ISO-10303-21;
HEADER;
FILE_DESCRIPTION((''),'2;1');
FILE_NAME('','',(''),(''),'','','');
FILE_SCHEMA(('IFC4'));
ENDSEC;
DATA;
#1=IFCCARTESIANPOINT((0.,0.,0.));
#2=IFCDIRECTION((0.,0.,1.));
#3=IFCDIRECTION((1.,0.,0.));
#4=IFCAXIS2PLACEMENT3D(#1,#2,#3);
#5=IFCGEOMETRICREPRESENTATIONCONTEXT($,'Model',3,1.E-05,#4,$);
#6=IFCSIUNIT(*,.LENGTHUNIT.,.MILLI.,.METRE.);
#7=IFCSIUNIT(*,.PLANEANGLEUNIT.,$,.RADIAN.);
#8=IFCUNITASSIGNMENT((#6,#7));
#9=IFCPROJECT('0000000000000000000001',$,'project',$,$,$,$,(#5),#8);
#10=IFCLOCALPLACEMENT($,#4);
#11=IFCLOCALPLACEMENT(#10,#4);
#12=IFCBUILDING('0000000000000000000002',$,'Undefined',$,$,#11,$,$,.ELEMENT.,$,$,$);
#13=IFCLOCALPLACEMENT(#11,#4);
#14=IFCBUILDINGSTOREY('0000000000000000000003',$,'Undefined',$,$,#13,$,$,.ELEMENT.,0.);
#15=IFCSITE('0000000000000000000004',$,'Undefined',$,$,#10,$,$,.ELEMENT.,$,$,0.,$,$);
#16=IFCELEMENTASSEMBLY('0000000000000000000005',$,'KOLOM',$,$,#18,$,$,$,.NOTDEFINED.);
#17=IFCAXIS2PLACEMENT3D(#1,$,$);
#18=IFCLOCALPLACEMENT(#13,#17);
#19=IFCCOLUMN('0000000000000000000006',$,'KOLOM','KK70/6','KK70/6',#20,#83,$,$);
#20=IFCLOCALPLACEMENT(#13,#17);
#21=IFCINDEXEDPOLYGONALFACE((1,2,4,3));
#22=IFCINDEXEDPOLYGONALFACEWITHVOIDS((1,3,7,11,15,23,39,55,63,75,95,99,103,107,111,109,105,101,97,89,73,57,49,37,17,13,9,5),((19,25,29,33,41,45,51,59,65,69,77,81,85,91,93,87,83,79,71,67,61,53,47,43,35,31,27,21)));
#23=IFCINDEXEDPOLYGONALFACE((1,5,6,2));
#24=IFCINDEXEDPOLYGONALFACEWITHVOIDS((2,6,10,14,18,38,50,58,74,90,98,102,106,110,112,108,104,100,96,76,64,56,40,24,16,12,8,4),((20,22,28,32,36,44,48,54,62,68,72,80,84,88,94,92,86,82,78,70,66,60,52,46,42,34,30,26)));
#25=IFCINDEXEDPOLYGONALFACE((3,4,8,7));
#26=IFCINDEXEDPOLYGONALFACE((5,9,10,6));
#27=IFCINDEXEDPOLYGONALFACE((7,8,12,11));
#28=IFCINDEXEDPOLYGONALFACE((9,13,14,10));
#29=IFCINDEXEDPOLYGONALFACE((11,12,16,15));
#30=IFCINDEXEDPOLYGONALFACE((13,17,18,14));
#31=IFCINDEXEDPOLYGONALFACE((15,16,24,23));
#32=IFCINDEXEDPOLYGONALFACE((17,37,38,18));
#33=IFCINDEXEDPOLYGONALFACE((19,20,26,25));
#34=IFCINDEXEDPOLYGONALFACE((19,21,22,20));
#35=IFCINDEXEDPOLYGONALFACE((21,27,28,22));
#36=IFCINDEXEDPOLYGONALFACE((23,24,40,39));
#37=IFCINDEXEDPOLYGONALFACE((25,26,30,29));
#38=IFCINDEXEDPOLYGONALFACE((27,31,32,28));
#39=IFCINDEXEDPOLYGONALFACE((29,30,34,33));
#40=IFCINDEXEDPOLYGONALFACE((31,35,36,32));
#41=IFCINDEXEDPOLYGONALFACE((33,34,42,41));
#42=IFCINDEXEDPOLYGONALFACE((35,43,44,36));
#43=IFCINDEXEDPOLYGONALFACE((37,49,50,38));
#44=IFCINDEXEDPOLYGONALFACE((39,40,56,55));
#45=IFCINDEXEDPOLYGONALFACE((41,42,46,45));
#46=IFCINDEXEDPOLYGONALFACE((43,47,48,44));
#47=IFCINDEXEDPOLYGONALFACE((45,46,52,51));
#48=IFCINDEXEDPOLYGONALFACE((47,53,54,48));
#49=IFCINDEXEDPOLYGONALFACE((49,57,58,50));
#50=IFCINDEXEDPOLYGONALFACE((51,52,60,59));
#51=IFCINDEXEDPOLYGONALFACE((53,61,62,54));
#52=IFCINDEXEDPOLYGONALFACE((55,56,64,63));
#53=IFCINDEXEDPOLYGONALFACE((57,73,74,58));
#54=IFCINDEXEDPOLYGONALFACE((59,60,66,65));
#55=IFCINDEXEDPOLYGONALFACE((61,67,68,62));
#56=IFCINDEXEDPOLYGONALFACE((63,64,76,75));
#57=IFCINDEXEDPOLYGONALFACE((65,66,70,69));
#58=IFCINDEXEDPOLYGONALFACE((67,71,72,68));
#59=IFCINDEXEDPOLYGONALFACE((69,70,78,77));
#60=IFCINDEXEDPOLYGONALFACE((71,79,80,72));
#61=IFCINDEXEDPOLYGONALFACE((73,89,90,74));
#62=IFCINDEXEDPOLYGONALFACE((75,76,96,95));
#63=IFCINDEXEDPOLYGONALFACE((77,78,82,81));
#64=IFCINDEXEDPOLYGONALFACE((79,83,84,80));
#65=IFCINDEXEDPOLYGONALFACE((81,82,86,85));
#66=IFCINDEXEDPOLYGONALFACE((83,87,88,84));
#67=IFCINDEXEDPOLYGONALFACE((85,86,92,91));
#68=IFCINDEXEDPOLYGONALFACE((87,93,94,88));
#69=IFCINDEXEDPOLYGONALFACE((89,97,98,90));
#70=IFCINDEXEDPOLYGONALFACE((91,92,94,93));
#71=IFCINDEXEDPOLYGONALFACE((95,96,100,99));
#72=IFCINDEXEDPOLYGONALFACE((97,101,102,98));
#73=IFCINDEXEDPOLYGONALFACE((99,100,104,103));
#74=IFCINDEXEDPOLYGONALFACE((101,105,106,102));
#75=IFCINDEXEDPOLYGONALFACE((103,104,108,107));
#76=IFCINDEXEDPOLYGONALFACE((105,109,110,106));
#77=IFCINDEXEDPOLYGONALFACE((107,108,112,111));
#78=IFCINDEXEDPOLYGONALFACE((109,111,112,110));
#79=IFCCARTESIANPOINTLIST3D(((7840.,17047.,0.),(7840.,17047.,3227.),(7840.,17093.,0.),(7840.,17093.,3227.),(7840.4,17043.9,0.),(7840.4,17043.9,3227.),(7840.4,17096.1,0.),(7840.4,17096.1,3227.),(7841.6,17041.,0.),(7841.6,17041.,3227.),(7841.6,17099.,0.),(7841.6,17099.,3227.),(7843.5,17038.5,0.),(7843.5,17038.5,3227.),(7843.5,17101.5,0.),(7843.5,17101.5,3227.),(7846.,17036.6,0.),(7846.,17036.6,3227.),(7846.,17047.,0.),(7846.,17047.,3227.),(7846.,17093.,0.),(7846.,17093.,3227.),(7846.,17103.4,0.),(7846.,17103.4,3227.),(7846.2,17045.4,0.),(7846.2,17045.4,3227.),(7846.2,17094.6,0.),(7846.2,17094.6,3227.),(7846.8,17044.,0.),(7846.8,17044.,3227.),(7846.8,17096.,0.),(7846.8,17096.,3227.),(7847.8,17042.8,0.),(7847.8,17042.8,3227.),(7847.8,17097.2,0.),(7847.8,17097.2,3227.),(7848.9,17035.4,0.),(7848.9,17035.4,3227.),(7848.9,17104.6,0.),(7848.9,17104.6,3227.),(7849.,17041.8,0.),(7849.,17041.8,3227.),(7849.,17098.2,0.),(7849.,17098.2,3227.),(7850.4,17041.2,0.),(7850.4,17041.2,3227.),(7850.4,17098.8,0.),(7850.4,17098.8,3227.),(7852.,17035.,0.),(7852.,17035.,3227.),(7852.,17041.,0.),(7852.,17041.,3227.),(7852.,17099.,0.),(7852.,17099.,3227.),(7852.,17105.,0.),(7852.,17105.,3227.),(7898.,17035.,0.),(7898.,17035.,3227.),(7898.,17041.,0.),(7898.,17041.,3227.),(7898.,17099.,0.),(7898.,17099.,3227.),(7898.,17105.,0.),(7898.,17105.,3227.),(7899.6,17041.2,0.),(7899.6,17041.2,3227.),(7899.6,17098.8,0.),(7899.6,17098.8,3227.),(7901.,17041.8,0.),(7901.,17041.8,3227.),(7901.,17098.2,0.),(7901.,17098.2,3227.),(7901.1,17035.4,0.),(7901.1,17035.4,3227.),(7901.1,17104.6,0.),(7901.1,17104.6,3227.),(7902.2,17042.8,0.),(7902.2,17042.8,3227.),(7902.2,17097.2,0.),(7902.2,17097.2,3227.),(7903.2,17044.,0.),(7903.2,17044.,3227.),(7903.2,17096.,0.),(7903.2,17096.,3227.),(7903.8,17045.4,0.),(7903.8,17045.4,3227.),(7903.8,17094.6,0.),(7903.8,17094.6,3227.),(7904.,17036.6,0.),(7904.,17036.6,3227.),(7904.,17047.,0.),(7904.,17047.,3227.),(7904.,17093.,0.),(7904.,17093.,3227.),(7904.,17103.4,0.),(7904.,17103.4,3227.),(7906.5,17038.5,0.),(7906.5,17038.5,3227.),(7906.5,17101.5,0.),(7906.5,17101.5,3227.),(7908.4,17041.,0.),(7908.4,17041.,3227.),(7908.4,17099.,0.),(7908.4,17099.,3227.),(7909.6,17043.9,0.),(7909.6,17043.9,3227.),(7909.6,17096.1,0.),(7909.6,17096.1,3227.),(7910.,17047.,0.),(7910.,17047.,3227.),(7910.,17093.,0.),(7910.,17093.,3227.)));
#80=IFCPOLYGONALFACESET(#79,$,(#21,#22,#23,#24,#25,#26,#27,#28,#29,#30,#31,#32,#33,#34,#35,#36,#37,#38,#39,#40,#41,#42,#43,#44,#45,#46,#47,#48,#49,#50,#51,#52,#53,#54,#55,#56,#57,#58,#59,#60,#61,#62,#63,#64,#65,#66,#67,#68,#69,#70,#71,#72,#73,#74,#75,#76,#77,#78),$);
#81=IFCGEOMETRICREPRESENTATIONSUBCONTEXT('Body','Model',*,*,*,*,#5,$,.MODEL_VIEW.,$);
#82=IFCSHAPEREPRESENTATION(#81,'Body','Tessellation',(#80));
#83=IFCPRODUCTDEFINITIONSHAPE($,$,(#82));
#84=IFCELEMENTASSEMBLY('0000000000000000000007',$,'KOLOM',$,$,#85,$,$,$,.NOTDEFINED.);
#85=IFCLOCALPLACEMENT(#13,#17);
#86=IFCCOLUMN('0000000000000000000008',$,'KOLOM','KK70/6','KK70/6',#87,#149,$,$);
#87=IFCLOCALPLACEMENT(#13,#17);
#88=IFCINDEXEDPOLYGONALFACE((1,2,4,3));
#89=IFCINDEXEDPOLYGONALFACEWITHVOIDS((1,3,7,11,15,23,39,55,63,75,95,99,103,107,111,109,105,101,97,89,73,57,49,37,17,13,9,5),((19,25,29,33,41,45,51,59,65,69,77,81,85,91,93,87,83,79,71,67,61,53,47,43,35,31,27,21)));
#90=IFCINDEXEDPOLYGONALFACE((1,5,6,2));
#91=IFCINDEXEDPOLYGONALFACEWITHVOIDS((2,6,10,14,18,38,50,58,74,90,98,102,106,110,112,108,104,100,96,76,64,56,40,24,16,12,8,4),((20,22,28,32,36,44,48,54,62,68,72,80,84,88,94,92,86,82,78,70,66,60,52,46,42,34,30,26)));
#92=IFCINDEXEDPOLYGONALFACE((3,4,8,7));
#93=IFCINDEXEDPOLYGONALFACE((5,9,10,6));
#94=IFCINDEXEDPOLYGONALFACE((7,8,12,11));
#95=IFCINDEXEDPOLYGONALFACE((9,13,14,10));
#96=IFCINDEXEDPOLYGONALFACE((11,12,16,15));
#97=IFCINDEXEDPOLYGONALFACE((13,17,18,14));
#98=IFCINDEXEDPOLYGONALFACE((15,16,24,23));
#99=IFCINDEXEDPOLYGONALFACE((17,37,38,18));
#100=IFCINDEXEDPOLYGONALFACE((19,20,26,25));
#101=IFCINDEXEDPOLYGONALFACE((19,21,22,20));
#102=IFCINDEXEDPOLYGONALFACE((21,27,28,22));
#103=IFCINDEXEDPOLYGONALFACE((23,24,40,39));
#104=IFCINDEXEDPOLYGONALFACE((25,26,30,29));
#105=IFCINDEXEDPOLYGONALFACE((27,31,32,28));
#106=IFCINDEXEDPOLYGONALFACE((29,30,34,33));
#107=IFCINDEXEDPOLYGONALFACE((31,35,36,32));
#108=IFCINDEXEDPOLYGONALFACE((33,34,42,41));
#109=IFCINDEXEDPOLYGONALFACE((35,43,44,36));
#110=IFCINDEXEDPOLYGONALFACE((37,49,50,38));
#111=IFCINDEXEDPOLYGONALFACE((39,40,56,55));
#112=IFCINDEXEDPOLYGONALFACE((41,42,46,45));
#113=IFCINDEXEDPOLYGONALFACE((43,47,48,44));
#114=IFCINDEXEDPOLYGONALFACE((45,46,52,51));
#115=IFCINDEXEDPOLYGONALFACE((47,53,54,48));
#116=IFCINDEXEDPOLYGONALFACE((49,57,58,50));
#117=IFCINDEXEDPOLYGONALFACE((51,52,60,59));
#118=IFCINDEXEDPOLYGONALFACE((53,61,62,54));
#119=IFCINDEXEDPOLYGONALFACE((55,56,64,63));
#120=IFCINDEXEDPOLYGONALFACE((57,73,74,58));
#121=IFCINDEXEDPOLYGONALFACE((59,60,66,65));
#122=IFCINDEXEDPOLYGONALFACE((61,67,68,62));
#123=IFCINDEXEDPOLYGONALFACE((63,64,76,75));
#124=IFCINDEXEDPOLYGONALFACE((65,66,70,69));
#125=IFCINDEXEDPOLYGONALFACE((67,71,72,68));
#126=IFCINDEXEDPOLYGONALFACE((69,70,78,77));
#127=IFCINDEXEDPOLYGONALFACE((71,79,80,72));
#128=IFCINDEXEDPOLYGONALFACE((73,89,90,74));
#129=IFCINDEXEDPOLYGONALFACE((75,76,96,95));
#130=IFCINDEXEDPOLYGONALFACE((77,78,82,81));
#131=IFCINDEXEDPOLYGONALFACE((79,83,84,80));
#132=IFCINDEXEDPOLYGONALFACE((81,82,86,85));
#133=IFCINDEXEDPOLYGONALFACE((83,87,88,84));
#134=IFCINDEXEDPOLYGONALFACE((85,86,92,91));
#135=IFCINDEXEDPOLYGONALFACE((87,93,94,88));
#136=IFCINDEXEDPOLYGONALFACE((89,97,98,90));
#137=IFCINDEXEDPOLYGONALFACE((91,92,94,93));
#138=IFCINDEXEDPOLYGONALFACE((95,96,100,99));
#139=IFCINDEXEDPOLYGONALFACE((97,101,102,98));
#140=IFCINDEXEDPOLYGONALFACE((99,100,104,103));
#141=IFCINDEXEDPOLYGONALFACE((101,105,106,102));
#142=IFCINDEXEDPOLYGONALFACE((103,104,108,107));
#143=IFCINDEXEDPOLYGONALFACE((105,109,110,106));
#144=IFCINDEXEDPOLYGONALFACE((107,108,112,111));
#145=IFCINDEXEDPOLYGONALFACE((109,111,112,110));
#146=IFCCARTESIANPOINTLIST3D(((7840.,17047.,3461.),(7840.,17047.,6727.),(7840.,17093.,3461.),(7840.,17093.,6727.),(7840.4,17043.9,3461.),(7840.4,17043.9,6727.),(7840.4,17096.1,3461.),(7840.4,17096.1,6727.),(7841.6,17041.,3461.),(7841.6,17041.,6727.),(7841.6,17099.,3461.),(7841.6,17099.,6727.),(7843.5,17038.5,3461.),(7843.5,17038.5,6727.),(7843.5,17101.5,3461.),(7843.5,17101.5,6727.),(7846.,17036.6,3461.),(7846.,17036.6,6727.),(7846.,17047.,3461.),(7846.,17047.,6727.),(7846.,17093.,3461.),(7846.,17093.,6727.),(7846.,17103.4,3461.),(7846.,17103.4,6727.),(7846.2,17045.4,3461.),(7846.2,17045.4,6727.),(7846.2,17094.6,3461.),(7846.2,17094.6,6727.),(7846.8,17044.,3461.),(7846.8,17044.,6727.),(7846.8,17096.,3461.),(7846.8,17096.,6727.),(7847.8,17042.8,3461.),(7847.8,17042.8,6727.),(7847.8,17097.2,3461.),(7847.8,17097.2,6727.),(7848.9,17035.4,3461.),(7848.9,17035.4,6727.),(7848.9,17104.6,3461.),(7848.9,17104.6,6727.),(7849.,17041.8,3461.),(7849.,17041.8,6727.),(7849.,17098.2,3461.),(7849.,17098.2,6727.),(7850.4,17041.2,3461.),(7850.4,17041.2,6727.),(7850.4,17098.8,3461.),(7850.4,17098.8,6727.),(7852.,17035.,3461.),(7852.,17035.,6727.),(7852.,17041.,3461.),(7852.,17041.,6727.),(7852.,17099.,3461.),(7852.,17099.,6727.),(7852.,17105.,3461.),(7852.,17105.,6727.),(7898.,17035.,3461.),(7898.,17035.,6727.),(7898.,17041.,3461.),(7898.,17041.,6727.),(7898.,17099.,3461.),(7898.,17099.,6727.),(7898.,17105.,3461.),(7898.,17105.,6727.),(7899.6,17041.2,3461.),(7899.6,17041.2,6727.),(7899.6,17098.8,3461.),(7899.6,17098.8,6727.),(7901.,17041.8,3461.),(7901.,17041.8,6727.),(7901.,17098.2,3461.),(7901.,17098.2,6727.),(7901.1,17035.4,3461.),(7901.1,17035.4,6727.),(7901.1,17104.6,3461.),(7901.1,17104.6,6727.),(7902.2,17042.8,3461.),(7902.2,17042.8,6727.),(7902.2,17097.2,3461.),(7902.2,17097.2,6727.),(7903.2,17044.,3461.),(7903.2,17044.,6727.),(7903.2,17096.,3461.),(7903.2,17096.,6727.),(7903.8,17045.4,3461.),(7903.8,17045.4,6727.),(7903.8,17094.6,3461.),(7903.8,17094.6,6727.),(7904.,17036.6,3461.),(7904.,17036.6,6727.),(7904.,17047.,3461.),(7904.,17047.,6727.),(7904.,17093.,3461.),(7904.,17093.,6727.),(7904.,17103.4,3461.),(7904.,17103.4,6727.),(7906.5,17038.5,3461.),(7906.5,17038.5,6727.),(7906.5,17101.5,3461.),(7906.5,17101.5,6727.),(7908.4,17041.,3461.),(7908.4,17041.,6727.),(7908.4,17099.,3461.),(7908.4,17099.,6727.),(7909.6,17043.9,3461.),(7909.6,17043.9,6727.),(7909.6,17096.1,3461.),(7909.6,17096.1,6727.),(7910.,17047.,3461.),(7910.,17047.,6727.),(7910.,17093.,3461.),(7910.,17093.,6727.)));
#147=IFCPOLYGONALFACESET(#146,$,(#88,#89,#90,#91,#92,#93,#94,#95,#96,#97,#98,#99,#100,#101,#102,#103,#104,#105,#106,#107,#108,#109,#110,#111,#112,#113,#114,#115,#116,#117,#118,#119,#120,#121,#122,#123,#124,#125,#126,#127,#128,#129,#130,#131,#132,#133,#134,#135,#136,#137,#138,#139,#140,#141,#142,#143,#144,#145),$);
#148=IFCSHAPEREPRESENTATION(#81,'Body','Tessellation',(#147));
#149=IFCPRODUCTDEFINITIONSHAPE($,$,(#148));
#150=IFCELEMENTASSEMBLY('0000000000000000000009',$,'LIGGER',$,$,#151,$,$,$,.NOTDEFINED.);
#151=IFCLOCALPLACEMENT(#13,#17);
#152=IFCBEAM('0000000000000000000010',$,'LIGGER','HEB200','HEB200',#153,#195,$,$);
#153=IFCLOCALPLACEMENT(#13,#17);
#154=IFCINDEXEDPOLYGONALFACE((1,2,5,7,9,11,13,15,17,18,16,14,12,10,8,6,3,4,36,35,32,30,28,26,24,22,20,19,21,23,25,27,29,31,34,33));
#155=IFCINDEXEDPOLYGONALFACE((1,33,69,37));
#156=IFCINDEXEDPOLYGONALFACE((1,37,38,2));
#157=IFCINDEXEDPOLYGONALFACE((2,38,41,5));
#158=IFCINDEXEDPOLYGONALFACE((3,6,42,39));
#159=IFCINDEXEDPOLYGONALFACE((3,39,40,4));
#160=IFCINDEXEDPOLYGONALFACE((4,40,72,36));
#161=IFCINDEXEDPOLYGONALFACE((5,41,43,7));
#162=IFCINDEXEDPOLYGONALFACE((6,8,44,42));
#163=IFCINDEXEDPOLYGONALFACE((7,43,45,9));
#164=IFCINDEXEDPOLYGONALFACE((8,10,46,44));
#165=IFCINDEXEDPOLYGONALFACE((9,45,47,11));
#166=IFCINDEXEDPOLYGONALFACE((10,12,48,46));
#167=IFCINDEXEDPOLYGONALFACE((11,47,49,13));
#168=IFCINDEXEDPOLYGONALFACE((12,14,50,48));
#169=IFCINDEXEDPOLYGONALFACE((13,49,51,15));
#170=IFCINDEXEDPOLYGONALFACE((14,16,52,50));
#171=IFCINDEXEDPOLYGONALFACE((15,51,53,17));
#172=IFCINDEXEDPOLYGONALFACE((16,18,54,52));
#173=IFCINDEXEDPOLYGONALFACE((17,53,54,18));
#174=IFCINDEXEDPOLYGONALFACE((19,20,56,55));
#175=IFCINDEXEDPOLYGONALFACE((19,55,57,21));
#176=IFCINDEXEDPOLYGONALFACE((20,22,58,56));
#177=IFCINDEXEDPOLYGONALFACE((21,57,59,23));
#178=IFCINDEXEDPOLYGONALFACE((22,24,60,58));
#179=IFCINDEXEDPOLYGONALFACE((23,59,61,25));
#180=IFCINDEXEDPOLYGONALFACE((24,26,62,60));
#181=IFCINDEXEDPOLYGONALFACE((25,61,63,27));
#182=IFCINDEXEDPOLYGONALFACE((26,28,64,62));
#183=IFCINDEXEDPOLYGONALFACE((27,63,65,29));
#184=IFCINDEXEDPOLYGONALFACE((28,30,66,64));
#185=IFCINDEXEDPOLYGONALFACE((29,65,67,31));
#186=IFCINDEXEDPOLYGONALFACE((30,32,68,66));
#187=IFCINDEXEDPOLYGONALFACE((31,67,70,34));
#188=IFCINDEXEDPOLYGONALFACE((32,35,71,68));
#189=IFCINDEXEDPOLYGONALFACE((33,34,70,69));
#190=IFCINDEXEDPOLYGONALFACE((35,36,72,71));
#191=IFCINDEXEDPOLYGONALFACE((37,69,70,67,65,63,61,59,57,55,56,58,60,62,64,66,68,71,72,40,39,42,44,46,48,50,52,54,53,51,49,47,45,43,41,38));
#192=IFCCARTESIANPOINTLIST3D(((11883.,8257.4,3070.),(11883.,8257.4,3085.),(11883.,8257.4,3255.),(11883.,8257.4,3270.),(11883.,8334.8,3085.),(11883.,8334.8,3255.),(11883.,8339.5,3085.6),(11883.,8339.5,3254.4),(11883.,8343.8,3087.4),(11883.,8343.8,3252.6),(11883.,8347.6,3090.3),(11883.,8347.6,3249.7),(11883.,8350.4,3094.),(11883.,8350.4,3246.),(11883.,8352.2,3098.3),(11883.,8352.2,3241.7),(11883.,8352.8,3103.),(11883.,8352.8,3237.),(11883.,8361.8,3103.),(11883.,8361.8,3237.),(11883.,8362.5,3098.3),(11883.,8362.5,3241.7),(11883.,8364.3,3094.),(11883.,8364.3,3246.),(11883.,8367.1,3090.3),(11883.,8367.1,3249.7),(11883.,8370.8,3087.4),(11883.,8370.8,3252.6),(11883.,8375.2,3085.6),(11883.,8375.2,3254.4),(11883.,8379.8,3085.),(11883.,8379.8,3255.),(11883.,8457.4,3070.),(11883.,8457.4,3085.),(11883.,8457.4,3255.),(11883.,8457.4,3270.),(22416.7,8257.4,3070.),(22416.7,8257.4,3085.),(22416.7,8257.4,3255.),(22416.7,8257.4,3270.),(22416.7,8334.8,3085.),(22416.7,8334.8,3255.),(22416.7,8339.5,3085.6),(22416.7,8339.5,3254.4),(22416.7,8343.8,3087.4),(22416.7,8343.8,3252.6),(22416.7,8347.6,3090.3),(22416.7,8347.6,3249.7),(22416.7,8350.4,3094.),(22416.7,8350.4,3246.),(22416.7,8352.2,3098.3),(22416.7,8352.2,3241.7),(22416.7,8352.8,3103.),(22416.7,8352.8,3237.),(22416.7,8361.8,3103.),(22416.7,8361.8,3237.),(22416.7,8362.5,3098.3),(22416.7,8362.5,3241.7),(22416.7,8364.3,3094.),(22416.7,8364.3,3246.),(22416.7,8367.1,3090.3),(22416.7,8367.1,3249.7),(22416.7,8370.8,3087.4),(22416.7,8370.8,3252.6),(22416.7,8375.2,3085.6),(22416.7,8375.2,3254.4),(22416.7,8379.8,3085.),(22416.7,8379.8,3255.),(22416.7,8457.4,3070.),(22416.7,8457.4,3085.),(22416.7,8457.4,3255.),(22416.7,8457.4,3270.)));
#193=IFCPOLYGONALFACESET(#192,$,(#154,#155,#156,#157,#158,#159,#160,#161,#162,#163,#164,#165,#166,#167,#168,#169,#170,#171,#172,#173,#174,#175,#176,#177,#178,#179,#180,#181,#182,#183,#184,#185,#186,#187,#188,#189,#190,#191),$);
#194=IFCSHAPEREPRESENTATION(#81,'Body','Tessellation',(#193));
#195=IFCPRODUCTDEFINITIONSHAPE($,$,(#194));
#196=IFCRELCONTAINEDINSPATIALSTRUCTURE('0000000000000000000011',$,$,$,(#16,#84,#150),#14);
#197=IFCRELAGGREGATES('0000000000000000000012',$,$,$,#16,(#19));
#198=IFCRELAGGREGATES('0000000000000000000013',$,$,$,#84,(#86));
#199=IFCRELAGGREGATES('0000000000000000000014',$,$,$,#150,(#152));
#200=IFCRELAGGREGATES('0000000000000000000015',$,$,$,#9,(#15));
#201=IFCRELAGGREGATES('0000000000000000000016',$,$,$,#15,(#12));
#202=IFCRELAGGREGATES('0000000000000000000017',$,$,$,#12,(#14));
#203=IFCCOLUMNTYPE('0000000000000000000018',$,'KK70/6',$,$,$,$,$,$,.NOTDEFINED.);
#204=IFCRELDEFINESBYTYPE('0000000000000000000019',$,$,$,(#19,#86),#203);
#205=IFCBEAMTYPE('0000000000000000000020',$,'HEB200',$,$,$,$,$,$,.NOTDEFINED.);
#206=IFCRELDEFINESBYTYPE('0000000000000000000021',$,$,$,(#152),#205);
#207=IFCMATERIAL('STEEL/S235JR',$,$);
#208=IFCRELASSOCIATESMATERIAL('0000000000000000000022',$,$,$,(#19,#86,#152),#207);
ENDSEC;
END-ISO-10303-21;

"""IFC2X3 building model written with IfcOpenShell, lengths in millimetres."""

from ifc_helpers import new_model, si_unit, frame, origin_with_axes, origin_2d_with_axis, place, context, subcontext, project, spatial, hollow_rectangle, i_section, extrude, material, type_object, element, aggregate, save


model = new_model("IFC2X3")

# Units and contexts
model_context = context("Model", 3, precision=1e-05, world=origin_with_axes())
body_context = subcontext(model_context, "Body", "Model", "MODEL_VIEW")
ifc_project = project(units=[si_unit("LENGTHUNIT", "METRE", prefix="MILLI"), si_unit("PLANEANGLEUNIT", "RADIAN")], contexts=[model_context])

# Site, building, storey
site_placement = place(None, origin_with_axes())
site = spatial("IfcSite", under=ifc_project, at=site_placement, Name="Undefined", CompositionType="ELEMENT", RefElevation=0.0)
building_placement = place(site_placement, origin_with_axes())
building = spatial("IfcBuilding", under=site, at=building_placement, Name="Undefined", CompositionType="ELEMENT")
storey_placement = place(building_placement, origin_with_axes())
storey = spatial("IfcBuildingStorey", under=building, at=storey_placement, Name="Undefined", CompositionType="ELEMENT", Elevation=0.0)

# Element assemblies, columns
ifc_material = material(Name="STEEL/S235JR")
column_type = type_object("IfcColumnType", Name="KK70/6", PredefinedType="NOTDEFINED")
assembly_1_placement = place(storey_placement, origin_with_axes())
assembly_1 = element("IfcElementAssembly", 1, at=assembly_1_placement, inside=storey, Name="KOLOM", PredefinedType="NOTDEFINED")
column_1_placement = place(assembly_1_placement, frame((7875.0, 17070.0, 0.0), z_axis=(0.0, 0.0, 1.0), x_axis=(1.0, 0.0, 0.0)))
column_1 = element("IfcColumn", 2, at=column_1_placement, type_object=column_type, material=ifc_material, Name="KOLOM", Description="KK70/6", ObjectType="KK70/6", context=body_context, shape_type="SweptSolid", body=[
    extrude(hollow_rectangle(XDim=70.0, YDim=70.0, WallThickness=6.0, InnerFilletRadius=6.0, OuterFilletRadius=12.0, at=origin_2d_with_axis()), frame((0.0, 0.0, 3227.0), z_axis=(0.0, 0.0, -1.0), x_axis=(0.0, -1.0, 0.0)), (0.0, 0.0, 1.0), 3227.0),
])
assembly_2_placement = place(storey_placement, origin_with_axes())
assembly_2 = element("IfcElementAssembly", 3, at=assembly_2_placement, inside=storey, Name="KOLOM", PredefinedType="NOTDEFINED")
column_2_placement = place(assembly_2_placement, frame((7875.0, 17070.0, 3450.0), z_axis=(0.0, 0.0, 1.0), x_axis=(1.0, 0.0, 0.0)))
column_2 = element("IfcColumn", 4, at=column_2_placement, type_object=column_type, material=ifc_material, Name="KOLOM", Description="KK70/6", ObjectType="KK70/6", context=body_context, shape_type="SweptSolid", body=[
    extrude(hollow_rectangle(XDim=70.0, YDim=70.0, WallThickness=6.0, InnerFilletRadius=6.0, OuterFilletRadius=12.0, at=origin_2d_with_axis()), frame((0.0, 0.0, 3277.0), z_axis=(0.0, 0.0, -1.0), x_axis=(0.0, -1.0, 0.0)), (0.0, 0.0, 1.0), 3266.0),
])

# Element assembly, beam
assembly_3_placement = place(storey_placement, origin_with_axes())
assembly_3 = element("IfcElementAssembly", 5, at=assembly_3_placement, inside=storey, Name="LIGGER", PredefinedType="NOTDEFINED")
beam_type_1 = type_object("IfcBeamType", Name="HEB200", PredefinedType="NOTDEFINED")
beam_1_placement = place(assembly_3_placement, frame((11875.0, 8357.4, 3170.0), z_axis=(0.0, 0.0, 1.0), x_axis=(1.0, 0.0, 0.0)))
beam_1 = element("IfcBeam", 6, at=beam_1_placement, type_object=beam_type_1, material=ifc_material, Name="LIGGER", Description="HEB200", ObjectType="HEB200", context=body_context, shape_type="SweptSolid", body=[
    extrude(i_section(OverallWidth=200.0, OverallDepth=200.0, WebThickness=9.0, FlangeThickness=15.0, FilletRadius=18.0, at=origin_2d_with_axis()), frame((10541.7, 0.0, 0.0), z_axis=(-1.0, 0.0, 0.0), x_axis=(0.0, -1.0, 0.0)), (0.0, 0.0, 1.0), 10533.7),
])

aggregate(assembly_1, [column_1])
aggregate(assembly_2, [column_2])
aggregate(assembly_3, [beam_1])

save(model, "model.ifc")
